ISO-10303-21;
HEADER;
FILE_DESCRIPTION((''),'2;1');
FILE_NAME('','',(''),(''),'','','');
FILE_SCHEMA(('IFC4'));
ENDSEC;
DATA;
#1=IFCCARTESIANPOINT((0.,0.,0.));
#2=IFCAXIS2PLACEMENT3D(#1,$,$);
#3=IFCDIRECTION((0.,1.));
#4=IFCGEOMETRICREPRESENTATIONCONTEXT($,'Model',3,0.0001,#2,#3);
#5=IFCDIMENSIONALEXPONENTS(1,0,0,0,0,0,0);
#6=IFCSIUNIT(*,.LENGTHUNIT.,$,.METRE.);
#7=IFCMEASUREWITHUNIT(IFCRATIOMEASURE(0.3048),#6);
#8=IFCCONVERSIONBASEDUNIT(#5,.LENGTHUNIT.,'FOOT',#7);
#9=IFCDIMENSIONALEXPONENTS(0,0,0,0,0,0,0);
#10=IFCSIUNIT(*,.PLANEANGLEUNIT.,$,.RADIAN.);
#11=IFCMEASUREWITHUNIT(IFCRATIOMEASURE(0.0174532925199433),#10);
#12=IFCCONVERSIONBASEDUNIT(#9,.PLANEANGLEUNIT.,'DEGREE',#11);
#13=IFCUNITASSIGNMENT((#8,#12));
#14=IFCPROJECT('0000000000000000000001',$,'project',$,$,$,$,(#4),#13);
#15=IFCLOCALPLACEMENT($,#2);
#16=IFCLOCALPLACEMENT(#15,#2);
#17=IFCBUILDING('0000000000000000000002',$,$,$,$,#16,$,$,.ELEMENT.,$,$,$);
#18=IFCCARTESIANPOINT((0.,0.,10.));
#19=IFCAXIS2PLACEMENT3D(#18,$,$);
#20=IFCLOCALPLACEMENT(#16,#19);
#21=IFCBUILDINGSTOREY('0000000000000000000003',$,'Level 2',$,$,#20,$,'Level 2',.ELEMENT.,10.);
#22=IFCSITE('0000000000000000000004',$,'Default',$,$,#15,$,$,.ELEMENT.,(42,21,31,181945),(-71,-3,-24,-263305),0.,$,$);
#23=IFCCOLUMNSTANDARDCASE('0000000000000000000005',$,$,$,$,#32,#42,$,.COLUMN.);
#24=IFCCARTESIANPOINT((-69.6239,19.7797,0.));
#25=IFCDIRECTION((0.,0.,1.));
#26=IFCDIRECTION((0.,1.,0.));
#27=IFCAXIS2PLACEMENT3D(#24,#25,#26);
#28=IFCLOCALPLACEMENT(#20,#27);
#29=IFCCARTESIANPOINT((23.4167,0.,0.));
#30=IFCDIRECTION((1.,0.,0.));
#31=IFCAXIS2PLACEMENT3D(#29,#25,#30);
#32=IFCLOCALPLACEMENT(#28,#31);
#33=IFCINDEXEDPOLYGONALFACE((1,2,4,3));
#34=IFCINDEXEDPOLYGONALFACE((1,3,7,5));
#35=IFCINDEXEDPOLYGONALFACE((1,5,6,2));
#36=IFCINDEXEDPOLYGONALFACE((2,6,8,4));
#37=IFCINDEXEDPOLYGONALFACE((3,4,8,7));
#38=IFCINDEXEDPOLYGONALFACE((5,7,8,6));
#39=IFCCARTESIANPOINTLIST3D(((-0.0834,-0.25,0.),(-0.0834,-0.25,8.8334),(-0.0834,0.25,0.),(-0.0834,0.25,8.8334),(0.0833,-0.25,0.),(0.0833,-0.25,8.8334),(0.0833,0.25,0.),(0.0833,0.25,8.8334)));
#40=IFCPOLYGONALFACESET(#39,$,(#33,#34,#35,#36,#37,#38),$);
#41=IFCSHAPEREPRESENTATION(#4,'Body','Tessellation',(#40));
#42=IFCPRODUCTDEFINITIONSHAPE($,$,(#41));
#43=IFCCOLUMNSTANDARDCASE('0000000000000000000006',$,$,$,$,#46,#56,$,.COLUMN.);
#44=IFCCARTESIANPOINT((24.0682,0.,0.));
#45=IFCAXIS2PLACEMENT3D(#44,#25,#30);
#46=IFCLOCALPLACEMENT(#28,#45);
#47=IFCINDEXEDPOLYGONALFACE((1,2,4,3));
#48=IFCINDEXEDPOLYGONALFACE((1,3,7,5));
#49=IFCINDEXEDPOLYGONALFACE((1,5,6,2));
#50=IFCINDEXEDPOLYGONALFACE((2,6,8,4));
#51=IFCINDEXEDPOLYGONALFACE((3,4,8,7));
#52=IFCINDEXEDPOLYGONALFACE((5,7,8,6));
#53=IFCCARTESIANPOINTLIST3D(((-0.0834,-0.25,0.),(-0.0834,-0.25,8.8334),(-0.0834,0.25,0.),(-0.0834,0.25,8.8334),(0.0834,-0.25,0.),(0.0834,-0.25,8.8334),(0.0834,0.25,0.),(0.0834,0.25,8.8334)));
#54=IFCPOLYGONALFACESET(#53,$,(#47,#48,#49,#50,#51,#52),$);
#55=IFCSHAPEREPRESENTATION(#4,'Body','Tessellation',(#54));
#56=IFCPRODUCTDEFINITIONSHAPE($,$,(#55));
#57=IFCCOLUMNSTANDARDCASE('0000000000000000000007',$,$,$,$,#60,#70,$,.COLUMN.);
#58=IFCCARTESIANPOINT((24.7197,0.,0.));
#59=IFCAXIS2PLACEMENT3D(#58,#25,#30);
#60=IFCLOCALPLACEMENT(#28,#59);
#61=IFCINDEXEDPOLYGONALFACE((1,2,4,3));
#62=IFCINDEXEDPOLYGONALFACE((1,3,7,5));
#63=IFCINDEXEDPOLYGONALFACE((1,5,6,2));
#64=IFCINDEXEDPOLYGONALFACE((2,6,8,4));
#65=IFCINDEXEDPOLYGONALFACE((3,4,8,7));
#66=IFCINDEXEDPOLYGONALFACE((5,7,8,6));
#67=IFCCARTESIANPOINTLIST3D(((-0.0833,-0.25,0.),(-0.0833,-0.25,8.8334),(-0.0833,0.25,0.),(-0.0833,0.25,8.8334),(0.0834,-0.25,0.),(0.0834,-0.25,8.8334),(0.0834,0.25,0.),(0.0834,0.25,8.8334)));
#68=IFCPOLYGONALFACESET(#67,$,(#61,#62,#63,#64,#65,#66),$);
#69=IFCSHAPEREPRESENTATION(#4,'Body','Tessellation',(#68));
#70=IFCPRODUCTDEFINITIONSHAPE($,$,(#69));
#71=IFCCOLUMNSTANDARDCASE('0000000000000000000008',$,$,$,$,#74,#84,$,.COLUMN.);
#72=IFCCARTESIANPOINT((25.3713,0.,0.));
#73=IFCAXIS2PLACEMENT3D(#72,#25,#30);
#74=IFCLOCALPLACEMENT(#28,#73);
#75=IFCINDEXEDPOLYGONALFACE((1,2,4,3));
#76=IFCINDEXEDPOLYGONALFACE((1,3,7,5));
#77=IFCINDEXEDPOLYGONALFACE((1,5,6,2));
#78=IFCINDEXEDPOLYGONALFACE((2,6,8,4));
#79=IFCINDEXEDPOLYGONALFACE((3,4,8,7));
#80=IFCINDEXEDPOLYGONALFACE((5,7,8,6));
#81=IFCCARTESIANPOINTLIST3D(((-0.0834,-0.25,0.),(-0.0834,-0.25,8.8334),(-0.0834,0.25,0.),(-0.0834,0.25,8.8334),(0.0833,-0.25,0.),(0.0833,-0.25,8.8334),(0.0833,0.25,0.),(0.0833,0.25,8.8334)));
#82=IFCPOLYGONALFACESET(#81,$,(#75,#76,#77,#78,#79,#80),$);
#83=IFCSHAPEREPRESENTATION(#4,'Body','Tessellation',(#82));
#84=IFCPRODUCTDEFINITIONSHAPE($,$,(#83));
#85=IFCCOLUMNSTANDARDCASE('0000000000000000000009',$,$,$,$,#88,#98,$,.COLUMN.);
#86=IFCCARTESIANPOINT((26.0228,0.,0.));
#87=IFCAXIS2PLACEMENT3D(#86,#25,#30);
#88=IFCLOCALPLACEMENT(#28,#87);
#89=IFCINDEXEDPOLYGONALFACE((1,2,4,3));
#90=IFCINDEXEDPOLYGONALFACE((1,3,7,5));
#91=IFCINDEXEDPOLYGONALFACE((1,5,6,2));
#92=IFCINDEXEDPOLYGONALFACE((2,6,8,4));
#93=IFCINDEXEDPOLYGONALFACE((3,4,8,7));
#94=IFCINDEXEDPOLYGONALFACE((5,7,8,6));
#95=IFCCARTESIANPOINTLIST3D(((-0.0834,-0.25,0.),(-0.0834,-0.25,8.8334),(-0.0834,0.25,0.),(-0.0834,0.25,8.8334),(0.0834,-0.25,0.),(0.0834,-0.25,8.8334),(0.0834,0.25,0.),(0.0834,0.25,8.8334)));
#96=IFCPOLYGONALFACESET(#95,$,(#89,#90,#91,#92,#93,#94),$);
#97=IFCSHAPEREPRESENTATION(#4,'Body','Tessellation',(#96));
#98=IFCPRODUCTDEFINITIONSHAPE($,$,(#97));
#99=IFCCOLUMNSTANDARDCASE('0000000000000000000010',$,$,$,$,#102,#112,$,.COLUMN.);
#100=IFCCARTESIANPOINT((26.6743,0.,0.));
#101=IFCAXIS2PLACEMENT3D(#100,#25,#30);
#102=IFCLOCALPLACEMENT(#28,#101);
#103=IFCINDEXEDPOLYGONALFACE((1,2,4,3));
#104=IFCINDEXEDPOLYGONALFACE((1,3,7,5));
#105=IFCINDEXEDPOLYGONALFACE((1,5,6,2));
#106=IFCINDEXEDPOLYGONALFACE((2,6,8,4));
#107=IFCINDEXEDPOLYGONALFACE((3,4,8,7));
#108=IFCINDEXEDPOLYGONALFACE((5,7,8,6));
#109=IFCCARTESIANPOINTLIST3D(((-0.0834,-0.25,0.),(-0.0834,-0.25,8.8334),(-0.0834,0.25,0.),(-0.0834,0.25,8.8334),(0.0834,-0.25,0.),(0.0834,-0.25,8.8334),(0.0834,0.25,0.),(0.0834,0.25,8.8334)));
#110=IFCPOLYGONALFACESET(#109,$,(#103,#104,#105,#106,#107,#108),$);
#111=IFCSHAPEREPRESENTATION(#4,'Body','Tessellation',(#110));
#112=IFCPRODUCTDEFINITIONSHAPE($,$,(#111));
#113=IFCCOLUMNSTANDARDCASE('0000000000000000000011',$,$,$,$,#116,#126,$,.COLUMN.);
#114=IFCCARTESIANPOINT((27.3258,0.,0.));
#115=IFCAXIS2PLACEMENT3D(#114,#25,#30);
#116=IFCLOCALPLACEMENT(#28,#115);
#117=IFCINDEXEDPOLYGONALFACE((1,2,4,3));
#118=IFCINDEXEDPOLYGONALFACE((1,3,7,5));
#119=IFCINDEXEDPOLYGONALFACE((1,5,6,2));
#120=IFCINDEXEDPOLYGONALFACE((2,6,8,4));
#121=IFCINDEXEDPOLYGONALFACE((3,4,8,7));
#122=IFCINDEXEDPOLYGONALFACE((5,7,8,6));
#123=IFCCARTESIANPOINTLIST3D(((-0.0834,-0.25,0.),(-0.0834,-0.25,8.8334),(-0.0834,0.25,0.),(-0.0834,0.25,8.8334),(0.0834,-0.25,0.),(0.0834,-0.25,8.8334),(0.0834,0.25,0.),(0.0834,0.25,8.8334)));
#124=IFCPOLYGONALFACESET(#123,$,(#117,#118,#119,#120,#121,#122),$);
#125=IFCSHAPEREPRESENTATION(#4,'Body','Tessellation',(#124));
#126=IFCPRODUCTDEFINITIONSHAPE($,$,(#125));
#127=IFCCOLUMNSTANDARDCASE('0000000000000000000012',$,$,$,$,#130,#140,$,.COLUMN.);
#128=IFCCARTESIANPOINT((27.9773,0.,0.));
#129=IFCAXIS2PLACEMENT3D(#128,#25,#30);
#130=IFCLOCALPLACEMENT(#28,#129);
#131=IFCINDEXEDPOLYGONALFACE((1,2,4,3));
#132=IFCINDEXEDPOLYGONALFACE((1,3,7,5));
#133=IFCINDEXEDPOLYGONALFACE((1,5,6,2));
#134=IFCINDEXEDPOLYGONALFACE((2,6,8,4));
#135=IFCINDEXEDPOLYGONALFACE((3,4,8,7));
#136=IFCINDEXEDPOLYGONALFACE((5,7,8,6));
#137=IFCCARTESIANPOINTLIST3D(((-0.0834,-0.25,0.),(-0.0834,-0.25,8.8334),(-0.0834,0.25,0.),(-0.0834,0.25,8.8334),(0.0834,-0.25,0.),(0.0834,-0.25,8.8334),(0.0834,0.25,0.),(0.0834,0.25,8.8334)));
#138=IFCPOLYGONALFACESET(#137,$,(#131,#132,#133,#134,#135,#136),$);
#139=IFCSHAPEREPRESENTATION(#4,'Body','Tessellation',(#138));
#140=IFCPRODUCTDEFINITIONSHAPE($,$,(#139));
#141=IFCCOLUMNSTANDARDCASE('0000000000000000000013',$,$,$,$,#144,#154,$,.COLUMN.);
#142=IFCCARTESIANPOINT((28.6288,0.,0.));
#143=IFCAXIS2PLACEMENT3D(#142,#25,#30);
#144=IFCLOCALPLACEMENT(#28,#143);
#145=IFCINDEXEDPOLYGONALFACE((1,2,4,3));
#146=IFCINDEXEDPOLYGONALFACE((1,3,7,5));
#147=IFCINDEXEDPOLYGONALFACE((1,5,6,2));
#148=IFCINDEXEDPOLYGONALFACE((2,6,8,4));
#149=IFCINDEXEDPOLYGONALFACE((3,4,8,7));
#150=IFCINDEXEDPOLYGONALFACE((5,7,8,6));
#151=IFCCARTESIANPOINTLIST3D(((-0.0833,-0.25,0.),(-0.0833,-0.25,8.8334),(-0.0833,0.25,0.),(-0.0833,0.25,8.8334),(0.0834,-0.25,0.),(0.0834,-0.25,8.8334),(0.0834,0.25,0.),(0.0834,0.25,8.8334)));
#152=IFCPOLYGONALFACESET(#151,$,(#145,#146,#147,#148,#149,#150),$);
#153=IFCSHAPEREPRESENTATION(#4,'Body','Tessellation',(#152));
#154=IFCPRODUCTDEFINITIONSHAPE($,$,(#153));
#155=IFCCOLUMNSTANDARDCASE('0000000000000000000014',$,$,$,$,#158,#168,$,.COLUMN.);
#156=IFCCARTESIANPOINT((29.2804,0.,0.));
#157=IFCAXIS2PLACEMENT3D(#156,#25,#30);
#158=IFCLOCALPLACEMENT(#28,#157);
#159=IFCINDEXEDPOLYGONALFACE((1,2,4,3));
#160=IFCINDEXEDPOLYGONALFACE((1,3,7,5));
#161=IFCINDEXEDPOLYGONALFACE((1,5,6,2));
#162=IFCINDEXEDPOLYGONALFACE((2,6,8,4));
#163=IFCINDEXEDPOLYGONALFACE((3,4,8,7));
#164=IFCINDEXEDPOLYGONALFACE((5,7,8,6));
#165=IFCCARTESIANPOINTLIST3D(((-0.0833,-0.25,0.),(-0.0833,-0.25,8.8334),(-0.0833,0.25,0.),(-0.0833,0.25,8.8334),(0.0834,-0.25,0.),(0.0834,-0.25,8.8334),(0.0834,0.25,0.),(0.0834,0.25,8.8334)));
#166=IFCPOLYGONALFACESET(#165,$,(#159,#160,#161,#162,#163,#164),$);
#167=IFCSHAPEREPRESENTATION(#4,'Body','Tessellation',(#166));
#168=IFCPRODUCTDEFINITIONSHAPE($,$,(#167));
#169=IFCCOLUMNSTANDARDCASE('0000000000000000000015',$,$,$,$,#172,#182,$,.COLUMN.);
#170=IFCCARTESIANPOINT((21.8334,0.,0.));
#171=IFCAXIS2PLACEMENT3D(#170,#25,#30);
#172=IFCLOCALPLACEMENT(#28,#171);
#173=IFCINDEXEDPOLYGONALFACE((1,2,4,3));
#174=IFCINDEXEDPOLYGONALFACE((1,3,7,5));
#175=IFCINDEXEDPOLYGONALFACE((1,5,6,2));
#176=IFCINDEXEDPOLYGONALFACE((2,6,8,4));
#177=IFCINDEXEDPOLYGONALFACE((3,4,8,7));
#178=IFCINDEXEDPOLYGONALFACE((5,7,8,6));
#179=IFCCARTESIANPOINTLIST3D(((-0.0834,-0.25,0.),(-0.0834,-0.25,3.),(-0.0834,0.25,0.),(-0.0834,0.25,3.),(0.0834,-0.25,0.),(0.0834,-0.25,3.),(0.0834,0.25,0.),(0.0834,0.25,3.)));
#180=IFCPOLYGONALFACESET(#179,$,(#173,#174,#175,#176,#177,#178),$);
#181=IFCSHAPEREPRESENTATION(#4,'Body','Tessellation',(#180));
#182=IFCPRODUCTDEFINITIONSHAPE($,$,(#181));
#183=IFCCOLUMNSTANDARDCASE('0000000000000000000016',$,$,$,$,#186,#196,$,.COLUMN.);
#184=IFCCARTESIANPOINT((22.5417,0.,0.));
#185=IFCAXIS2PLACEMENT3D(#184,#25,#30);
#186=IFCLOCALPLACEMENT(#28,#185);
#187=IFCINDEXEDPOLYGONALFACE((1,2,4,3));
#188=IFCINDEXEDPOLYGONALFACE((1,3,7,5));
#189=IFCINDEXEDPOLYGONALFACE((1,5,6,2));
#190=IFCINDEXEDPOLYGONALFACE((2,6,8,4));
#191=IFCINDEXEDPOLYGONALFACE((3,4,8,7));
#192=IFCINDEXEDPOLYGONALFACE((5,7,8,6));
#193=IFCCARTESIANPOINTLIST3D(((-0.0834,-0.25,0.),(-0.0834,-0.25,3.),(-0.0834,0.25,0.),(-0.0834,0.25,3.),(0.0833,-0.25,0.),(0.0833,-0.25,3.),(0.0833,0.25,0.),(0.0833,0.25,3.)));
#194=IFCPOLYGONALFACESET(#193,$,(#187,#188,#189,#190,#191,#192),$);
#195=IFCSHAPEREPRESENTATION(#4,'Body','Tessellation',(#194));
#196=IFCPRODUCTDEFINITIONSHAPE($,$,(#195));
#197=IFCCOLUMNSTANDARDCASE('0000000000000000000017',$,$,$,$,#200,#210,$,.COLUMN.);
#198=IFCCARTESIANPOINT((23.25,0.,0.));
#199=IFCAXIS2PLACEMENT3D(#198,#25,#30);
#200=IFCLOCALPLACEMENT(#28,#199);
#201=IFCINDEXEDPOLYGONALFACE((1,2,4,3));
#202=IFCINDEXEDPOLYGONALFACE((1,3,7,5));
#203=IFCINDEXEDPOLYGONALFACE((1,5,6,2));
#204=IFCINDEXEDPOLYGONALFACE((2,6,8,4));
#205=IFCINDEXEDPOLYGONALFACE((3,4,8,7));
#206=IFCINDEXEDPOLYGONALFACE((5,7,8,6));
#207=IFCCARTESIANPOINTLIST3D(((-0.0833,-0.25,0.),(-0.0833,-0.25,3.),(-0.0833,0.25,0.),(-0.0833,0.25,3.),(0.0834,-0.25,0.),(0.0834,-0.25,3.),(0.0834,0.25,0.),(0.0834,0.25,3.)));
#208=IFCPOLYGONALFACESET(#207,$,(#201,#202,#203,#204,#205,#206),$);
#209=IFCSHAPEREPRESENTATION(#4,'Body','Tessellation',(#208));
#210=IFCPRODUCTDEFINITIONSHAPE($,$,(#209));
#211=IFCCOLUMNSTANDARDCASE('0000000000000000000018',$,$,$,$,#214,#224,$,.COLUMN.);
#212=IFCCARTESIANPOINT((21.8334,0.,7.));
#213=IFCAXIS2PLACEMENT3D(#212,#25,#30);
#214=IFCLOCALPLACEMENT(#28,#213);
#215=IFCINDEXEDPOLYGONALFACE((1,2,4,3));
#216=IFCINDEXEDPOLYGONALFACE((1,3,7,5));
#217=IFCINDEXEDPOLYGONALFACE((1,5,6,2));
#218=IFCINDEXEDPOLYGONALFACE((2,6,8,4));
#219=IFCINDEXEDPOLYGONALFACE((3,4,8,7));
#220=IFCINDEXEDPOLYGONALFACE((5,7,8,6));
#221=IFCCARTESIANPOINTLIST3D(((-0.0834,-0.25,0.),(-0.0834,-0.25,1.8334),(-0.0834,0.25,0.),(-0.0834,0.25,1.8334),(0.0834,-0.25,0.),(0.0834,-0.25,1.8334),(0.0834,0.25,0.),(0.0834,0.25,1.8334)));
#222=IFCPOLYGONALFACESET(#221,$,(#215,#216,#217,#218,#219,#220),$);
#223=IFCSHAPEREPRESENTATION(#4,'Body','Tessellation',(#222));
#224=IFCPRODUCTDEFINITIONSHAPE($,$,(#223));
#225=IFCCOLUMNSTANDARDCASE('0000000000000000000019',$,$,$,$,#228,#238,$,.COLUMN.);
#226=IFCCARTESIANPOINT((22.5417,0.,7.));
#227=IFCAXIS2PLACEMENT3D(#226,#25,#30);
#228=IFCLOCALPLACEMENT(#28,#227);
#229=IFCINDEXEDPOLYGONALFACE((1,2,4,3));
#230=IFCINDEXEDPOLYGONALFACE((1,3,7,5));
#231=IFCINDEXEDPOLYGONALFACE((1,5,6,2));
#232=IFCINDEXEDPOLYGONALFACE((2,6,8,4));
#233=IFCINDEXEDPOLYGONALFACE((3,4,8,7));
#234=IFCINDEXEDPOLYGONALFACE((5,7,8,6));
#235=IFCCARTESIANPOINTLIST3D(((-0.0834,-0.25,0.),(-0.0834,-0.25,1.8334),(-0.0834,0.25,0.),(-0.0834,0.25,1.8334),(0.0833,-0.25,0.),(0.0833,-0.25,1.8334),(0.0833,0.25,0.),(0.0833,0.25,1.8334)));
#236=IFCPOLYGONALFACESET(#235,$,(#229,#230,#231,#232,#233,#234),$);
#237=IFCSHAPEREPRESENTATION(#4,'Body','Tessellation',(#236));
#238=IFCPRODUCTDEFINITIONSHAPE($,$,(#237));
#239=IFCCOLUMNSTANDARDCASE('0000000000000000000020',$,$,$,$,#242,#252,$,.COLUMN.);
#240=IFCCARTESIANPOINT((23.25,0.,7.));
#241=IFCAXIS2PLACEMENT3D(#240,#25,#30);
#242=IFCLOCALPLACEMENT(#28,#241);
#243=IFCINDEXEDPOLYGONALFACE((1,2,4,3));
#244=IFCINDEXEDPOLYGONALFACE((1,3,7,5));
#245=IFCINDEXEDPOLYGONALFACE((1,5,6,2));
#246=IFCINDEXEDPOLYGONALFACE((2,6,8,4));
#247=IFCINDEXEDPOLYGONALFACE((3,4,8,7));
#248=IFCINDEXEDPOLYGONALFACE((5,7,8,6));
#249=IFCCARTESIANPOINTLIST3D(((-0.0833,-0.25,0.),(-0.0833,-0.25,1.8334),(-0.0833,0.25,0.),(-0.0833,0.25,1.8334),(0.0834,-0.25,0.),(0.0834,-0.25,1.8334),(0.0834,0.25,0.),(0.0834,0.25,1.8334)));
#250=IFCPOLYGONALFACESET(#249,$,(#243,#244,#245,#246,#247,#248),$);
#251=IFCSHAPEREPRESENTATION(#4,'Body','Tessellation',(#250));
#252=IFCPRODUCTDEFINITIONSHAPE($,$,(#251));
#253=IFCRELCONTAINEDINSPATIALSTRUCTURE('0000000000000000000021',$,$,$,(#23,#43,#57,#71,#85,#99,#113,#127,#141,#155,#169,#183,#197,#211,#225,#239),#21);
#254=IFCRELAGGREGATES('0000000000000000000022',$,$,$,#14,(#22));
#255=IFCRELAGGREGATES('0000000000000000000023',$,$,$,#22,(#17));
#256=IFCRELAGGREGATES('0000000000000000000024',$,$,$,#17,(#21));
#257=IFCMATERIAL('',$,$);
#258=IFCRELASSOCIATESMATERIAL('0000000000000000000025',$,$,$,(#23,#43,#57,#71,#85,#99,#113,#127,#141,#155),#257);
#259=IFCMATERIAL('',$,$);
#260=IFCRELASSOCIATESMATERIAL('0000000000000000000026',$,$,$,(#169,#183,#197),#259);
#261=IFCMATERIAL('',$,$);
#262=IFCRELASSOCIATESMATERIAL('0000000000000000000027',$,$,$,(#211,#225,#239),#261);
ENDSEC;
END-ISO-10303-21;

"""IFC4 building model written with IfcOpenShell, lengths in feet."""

from ifc_helpers import new_model, entity, si_unit, converted_unit, direction, frame, origin, place, context, project, spatial, rectangle, extrude, material, element, save


model = new_model("IFC4")

# Units and contexts
model_context = context("Model", 3, precision=0.0001, world=origin(), true_north=direction((0.0, 1.0)))
ifc_project = project(units=[converted_unit("LENGTHUNIT", "FOOT", entity("IfcRatioMeasure", 0.3048), si_unit("LENGTHUNIT", "METRE"), dimensions=[1, 0, 0, 0, 0, 0, 0]), converted_unit("PLANEANGLEUNIT", "DEGREE", entity("IfcRatioMeasure", 0.0174532925199433), si_unit("PLANEANGLEUNIT", "RADIAN"), dimensions=[0, 0, 0, 0, 0, 0, 0])], contexts=[model_context])

# Site, building, storey
site_placement = place(None, origin())
site = spatial("IfcSite", under=ifc_project, at=site_placement, Name="Default", CompositionType="ELEMENT", RefLatitude=(42, 21, 31, 181945), RefLongitude=(-71, -3, -24, -263305), RefElevation=0.0)
building_placement = place(site_placement, origin())
building = spatial("IfcBuilding", under=site, at=building_placement, CompositionType="ELEMENT")
storey_placement = place(building_placement, frame((0.0, 0.0, 10.0)))
storey = spatial("IfcBuildingStorey", under=building, at=storey_placement, Name="Level 2", LongName="Level 2", CompositionType="ELEMENT", Elevation=10.0)

# Columns
ifc_material_1 = material(Name="")
placement_1 = place(storey_placement, frame((-69.6239, 19.7797, 0.0), z_axis=(0.0, 0.0, 1.0), x_axis=(0.0, 1.0, 0.0)))
for number, where, z_axis, x_axis in (
    (1, (23.4167, 0.0, 0.0), (0.0, 0.0, 1.0), (1.0, 0.0, 0.0)),
    (2, (24.0682, 0.0, 0.0), (0.0, 0.0, 1.0), (1.0, 0.0, 0.0)),
    (3, (24.7197, 0.0, 0.0), (0.0, 0.0, 1.0), (1.0, 0.0, 0.0)),
    (4, (25.3713, 0.0, 0.0), (0.0, 0.0, 1.0), (1.0, 0.0, 0.0)),
    (5, (26.0228, 0.0, 0.0), (0.0, 0.0, 1.0), (1.0, 0.0, 0.0)),
    (6, (26.6743, 0.0, 0.0), (0.0, 0.0, 1.0), (1.0, 0.0, 0.0)),
    (7, (27.3258, 0.0, 0.0), (0.0, 0.0, 1.0), (1.0, 0.0, 0.0)),
    (8, (27.9773, 0.0, 0.0), (0.0, 0.0, 1.0), (1.0, 0.0, 0.0)),
    (9, (28.6288, 0.0, 0.0), (0.0, 0.0, 1.0), (1.0, 0.0, 0.0)),
    (10, (29.2804, 0.0, 0.0), (0.0, 0.0, 1.0), (1.0, 0.0, 0.0)),
):
    element("IfcColumnStandardCase", number, at=place(placement_1, frame(where, z_axis=z_axis, x_axis=x_axis)), inside=storey, material=ifc_material_1, PredefinedType="COLUMN", context=model_context, shape_type="SweptSolid", body=[
        extrude(rectangle(XDim=0.1667, YDim=0.5), origin(), (0.0, 0.0, 1.0), 8.8334),
    ])
ifc_material_2 = material(Name="")
for number, where, z_axis, x_axis in (
    (11, (21.8334, 0.0, 0.0), (0.0, 0.0, 1.0), (1.0, 0.0, 0.0)),
    (12, (22.5417, 0.0, 0.0), (0.0, 0.0, 1.0), (1.0, 0.0, 0.0)),
    (13, (23.25, 0.0, 0.0), (0.0, 0.0, 1.0), (1.0, 0.0, 0.0)),
):
    element("IfcColumnStandardCase", number, at=place(placement_1, frame(where, z_axis=z_axis, x_axis=x_axis)), inside=storey, material=ifc_material_2, PredefinedType="COLUMN", context=model_context, shape_type="SweptSolid", body=[
        extrude(rectangle(XDim=0.1667, YDim=0.5), origin(), (0.0, 0.0, 1.0), 3.0),
    ])
ifc_material_3 = material(Name="")
for number, where, z_axis, x_axis in (
    (14, (21.8334, 0.0, 7.0), (0.0, 0.0, 1.0), (1.0, 0.0, 0.0)),
    (15, (22.5417, 0.0, 7.0), (0.0, 0.0, 1.0), (1.0, 0.0, 0.0)),
    (16, (23.25, 0.0, 7.0), (0.0, 0.0, 1.0), (1.0, 0.0, 0.0)),
):
    element("IfcColumnStandardCase", number, at=place(placement_1, frame(where, z_axis=z_axis, x_axis=x_axis)), inside=storey, material=ifc_material_3, PredefinedType="COLUMN", context=model_context, shape_type="SweptSolid", body=[
        extrude(rectangle(XDim=0.1667, YDim=0.5), origin(), (0.0, 0.0, 1.0), 1.8334),
    ])

save(model, "model.ifc")
